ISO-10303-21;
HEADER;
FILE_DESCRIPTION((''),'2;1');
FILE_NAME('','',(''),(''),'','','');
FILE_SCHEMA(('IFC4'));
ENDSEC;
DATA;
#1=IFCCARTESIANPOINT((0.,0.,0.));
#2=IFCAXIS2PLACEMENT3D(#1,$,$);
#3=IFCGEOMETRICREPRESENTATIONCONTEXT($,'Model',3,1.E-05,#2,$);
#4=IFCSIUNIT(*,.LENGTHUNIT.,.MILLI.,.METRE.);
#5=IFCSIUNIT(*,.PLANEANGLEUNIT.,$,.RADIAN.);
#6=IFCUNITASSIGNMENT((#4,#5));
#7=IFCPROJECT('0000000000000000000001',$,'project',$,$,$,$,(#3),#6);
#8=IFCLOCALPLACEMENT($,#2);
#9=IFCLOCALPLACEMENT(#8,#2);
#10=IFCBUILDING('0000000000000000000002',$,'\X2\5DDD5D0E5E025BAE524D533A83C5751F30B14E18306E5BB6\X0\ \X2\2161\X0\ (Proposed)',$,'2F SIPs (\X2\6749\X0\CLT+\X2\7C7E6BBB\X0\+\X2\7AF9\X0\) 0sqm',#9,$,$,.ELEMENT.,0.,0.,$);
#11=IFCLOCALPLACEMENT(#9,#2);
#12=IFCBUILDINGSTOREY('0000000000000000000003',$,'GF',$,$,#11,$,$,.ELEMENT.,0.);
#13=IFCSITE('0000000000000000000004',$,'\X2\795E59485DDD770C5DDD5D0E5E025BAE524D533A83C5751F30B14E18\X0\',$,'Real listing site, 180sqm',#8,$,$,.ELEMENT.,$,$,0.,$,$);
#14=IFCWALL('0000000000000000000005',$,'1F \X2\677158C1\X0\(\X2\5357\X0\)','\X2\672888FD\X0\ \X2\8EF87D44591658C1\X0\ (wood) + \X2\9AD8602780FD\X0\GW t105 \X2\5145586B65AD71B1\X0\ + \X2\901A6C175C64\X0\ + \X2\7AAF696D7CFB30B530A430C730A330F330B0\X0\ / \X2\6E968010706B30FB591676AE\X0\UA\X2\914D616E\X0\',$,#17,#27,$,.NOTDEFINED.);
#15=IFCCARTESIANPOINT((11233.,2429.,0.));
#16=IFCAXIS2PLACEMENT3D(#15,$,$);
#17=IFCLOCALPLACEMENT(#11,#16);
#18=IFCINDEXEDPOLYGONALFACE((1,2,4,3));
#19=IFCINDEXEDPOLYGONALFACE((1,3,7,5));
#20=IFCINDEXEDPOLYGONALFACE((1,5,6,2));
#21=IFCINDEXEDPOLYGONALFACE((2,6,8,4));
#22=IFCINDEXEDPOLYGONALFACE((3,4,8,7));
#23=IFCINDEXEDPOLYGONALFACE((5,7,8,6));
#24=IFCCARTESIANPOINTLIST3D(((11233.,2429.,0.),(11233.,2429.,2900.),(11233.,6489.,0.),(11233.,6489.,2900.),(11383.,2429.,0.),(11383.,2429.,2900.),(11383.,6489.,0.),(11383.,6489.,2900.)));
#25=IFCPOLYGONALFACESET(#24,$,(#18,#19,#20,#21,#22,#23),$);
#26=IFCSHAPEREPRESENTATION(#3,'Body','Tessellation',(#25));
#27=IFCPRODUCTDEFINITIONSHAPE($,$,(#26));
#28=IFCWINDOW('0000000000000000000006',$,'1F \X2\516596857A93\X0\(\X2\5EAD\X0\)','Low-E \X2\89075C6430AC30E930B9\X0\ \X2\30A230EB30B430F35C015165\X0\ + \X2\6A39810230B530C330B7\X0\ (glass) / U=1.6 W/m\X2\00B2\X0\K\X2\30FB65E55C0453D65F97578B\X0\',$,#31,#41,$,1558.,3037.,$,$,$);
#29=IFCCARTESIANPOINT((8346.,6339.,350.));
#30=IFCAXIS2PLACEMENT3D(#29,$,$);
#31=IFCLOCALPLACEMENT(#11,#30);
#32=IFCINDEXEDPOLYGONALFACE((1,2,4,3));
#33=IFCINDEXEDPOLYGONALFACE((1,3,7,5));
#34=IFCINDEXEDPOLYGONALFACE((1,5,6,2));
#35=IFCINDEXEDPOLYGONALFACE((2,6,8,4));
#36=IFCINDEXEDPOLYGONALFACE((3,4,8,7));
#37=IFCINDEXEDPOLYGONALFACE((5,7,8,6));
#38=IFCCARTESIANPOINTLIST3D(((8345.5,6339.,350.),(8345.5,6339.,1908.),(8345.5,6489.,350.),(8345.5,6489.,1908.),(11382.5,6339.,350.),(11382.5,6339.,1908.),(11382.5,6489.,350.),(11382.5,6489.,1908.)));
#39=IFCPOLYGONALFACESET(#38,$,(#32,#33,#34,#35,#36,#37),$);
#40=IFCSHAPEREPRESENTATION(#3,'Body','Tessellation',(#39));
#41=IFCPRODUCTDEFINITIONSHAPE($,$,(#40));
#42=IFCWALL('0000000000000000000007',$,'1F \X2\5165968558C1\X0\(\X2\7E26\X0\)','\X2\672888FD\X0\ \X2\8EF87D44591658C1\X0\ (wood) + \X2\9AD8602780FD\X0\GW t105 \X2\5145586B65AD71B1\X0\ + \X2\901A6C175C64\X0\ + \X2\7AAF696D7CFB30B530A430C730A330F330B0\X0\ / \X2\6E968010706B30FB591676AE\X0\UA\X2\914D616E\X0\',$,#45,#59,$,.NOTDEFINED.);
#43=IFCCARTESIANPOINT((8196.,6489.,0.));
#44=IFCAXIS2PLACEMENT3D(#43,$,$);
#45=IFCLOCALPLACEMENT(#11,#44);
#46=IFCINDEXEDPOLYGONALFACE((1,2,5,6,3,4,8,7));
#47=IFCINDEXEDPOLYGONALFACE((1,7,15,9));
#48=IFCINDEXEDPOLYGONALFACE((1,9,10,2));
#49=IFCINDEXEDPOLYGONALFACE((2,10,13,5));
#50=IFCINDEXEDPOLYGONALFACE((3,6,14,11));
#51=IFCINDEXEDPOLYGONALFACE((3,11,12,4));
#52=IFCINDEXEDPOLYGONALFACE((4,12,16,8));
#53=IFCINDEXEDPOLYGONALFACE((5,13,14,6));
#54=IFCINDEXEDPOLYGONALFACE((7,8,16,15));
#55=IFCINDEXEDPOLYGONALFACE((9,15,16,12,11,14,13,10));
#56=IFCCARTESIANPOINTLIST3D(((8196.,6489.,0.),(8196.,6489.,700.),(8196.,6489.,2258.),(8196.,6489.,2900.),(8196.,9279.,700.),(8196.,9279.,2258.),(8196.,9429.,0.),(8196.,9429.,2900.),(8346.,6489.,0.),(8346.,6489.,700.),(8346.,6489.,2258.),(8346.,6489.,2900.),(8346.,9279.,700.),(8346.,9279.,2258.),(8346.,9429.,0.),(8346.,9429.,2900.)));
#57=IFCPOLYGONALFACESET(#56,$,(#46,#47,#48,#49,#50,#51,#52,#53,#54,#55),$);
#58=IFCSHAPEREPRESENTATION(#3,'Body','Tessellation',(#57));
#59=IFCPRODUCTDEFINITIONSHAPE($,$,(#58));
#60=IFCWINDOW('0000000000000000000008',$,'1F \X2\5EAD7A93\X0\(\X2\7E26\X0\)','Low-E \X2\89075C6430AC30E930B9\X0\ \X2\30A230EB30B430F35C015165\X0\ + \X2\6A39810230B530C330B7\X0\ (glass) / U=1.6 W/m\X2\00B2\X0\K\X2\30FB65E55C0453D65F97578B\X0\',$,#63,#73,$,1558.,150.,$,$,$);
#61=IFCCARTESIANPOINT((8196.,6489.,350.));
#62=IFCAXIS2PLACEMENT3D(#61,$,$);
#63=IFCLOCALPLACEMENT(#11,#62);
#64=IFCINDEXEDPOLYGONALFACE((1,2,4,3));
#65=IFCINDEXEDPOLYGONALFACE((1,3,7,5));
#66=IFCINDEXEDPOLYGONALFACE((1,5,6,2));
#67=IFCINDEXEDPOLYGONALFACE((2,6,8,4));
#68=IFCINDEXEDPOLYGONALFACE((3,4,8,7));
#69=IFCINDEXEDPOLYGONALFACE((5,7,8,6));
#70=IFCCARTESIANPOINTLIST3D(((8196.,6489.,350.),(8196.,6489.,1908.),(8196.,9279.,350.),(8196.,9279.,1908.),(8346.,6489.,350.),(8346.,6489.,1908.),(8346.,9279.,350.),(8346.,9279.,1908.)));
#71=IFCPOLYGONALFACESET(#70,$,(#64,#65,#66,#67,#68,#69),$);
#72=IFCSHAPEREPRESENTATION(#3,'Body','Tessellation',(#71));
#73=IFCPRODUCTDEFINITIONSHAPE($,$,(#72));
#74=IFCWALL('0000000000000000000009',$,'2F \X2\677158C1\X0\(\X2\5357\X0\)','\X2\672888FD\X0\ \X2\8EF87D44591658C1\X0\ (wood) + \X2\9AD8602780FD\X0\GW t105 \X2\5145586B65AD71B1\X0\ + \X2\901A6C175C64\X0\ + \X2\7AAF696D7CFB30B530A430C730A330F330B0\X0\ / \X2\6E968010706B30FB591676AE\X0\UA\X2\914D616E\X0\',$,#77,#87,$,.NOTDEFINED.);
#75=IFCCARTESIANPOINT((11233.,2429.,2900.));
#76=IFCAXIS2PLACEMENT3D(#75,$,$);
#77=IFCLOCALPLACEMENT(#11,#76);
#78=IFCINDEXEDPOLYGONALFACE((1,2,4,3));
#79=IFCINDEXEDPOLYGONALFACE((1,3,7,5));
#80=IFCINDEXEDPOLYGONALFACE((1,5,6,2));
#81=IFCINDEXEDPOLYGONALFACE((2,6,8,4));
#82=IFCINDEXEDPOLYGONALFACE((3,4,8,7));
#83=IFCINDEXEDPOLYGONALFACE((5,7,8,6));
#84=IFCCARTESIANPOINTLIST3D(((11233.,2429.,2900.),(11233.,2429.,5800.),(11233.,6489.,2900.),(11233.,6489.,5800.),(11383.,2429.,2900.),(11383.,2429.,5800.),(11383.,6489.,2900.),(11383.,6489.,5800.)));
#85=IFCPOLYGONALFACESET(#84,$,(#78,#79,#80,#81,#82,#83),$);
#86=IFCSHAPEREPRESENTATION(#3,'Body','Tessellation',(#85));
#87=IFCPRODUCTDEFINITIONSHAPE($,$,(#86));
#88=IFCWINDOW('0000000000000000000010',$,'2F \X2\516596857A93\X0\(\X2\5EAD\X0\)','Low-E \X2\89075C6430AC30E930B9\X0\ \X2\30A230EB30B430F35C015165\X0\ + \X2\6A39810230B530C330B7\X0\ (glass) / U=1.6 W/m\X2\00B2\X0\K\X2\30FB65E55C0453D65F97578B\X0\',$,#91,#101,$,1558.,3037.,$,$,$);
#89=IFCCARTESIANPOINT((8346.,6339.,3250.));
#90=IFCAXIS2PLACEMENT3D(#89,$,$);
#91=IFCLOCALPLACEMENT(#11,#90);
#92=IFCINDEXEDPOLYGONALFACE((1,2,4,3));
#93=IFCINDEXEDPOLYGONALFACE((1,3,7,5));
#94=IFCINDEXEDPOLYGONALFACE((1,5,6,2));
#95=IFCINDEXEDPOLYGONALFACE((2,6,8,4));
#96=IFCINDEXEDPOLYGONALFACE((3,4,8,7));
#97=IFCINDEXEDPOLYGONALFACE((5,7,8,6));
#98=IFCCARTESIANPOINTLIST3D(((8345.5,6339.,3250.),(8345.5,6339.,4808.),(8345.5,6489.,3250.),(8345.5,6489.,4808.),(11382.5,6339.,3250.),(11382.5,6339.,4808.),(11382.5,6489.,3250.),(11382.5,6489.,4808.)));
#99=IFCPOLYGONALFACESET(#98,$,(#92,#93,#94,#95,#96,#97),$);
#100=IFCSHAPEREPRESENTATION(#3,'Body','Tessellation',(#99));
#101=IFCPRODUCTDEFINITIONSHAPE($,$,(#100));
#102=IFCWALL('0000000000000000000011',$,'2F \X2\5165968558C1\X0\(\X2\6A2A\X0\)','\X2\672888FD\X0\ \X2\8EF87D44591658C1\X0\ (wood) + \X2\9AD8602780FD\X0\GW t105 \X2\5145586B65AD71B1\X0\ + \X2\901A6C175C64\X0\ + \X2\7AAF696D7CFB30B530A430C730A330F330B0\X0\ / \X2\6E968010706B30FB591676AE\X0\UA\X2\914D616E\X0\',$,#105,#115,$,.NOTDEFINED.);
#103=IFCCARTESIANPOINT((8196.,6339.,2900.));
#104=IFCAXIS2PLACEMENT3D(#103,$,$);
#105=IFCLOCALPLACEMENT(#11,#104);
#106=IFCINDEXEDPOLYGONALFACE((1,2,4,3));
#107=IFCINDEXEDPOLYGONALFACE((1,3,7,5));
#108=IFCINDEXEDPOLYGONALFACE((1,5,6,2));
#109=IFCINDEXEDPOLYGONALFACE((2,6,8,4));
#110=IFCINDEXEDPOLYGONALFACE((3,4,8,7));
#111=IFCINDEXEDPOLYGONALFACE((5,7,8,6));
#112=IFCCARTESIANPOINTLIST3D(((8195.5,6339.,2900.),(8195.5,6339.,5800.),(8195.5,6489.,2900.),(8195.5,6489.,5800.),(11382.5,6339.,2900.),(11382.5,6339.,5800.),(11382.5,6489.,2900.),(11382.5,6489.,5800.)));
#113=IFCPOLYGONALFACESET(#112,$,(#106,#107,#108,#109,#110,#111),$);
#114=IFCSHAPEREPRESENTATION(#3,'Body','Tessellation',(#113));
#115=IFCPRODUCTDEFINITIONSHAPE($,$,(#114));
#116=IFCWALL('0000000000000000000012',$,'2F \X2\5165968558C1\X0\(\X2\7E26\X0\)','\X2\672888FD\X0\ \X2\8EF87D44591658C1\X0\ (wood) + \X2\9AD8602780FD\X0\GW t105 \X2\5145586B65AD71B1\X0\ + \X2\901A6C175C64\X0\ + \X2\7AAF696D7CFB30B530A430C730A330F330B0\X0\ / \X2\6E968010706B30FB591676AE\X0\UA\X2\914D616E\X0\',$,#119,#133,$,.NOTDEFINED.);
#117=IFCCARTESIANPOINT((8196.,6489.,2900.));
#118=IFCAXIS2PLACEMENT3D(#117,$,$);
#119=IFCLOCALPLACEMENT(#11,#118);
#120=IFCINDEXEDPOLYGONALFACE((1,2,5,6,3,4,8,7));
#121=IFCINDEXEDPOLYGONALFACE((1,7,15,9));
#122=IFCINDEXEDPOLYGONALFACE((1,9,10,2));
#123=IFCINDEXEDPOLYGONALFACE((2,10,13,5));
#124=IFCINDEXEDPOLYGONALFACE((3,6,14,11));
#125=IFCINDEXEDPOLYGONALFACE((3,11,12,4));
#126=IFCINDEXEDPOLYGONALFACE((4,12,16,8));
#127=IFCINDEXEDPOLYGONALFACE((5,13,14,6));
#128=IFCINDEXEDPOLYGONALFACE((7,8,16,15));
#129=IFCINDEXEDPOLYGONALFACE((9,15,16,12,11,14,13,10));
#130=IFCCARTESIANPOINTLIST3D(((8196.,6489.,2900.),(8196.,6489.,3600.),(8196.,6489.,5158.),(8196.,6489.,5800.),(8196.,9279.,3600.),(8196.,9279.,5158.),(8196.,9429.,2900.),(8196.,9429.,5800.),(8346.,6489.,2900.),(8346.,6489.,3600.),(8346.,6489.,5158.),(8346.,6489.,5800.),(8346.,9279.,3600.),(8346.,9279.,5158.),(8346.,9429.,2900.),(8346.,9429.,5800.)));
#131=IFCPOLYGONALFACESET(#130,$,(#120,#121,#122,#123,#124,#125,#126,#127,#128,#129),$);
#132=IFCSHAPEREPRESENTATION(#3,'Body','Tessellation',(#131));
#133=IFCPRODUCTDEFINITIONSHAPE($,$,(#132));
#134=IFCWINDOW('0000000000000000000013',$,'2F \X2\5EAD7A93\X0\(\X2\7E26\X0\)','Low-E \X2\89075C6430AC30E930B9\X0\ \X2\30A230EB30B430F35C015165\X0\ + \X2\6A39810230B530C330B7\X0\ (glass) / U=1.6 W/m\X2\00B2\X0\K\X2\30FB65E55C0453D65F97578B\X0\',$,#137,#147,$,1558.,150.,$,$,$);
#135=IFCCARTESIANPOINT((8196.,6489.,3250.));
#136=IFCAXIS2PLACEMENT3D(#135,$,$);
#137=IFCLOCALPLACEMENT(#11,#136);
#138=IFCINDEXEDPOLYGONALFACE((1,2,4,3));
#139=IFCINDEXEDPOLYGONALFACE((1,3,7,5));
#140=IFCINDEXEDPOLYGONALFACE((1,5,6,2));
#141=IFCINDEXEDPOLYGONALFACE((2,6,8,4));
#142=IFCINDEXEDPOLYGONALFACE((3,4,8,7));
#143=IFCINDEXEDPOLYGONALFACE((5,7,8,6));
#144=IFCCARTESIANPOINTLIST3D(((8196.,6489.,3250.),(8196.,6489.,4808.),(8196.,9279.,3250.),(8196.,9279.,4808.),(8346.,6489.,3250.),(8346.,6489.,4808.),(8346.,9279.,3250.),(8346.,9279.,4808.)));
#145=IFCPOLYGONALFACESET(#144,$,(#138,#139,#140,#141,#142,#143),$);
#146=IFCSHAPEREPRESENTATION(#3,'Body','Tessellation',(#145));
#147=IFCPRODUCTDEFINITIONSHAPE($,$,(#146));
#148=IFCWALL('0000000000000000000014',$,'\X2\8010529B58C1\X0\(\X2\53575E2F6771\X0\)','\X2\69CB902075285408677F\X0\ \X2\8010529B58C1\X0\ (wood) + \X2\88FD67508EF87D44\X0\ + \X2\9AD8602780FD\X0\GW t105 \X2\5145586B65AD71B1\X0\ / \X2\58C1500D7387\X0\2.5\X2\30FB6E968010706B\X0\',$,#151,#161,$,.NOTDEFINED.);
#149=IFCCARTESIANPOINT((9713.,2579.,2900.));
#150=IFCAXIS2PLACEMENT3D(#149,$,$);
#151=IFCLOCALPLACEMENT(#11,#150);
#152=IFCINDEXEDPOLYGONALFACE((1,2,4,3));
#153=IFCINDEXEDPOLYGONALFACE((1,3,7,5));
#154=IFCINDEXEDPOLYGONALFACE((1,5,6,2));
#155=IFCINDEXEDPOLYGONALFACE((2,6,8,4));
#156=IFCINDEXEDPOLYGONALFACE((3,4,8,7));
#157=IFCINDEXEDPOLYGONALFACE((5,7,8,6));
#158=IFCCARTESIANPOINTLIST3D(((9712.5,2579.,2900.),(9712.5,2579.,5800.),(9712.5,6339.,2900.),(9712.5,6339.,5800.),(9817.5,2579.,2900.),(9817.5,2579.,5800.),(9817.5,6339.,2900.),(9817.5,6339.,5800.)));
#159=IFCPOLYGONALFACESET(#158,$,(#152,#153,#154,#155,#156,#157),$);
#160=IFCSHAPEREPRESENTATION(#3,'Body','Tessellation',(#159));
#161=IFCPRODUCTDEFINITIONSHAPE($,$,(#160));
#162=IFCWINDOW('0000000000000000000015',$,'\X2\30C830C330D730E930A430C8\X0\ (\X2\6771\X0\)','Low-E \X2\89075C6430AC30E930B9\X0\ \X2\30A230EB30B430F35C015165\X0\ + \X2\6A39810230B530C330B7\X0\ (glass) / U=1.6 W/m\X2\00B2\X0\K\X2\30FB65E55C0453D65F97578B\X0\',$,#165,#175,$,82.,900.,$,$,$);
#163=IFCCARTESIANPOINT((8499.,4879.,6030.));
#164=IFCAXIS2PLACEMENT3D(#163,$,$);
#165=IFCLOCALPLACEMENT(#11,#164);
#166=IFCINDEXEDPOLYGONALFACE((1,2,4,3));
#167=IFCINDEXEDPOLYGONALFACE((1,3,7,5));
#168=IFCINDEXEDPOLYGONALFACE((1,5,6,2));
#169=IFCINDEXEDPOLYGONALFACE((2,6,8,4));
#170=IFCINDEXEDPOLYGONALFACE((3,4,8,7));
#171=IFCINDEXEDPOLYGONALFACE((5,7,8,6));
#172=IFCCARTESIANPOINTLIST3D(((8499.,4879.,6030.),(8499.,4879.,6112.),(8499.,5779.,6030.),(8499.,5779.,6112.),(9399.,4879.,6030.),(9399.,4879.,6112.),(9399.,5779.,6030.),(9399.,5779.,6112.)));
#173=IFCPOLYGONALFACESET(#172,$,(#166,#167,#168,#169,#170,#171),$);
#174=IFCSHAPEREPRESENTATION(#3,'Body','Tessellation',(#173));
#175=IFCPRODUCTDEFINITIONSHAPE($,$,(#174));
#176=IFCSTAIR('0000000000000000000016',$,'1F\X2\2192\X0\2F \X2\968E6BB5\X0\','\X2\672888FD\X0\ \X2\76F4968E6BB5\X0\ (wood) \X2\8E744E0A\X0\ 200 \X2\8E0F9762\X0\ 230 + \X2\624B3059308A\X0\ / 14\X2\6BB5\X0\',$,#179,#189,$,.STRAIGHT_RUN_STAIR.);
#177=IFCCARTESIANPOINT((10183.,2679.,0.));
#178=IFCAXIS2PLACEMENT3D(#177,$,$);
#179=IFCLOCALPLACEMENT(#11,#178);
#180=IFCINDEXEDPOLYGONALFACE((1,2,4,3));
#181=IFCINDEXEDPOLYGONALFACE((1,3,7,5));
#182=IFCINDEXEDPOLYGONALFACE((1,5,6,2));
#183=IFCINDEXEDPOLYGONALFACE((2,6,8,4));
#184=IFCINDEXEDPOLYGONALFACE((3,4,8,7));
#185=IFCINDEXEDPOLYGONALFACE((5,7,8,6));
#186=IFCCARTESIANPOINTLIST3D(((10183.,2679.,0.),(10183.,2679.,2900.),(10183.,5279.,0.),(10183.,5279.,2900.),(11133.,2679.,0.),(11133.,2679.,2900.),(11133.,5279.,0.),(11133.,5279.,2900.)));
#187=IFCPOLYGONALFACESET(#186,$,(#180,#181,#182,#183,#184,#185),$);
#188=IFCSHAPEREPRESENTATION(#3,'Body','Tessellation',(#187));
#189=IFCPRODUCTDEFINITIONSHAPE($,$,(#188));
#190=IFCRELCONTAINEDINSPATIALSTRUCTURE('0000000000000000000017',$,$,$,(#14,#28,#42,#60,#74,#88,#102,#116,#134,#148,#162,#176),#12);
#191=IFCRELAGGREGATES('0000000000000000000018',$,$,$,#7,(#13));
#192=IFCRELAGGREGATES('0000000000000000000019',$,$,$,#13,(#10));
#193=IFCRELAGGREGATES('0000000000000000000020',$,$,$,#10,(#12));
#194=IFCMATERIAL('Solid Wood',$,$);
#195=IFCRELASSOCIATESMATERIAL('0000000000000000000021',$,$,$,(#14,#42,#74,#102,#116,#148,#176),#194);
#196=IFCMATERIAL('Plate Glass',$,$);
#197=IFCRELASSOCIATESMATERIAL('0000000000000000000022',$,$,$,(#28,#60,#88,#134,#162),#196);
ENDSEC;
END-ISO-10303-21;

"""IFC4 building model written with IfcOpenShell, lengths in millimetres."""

from ifc_helpers import new_model, si_unit, frame, frame_2d, origin, place, context, project, spatial, rectangle, extrude, material, element, fill, save


model = new_model("IFC4")

# Units and contexts
model_context = context("Model", 3, precision=1e-05, world=origin())
ifc_project = project(units=[si_unit("LENGTHUNIT", "METRE", prefix="MILLI"), si_unit("PLANEANGLEUNIT", "RADIAN")], contexts=[model_context])

# Site, building, storey
site_placement = place(None, origin())
site = spatial("IfcSite", under=ifc_project, at=site_placement, Name="神奈川県川崎市宮前区菅生ケ丘", ObjectType="Real listing site, 180sqm", CompositionType="ELEMENT", RefElevation=0.0)
building_placement = place(site_placement, origin())
building = spatial("IfcBuilding", under=site, at=building_placement, Name="川崎市宮前区菅生ケ丘の家 Ⅱ (Proposed)", ObjectType="2F SIPs (杉CLT+籾殻+竹) 0sqm", CompositionType="ELEMENT", ElevationOfRefHeight=0.0, ElevationOfTerrain=0.0)
storey_placement = place(building_placement, origin())
storey = spatial("IfcBuildingStorey", under=building, at=storey_placement, Name="GF", CompositionType="ELEMENT", Elevation=0.0)

# Shared definitions
ifc_material_1 = material(Name="Solid Wood")

# Wall, opening, window
wall_1_placement = place(storey_placement, frame((11233.0, 2429.0, 0.0)))
wall_1 = element("IfcWall", 1, at=wall_1_placement, inside=storey, material=ifc_material_1, Name="1F 東壁(南)", Description="木製 軸組外壁 (wood) + 高性能GW t105 充填断熱 + 通気層 + 窯業系サイディング / 準耐火・外皮UA配慮", PredefinedType="NOTDEFINED", context=model_context, shape_type="SweptSolid", body=[
    extrude(rectangle(XDim=150.0, YDim=4060.0, at=frame_2d((75.0, 2030.0))), frame((11233.0, 2429.0, 0.0)), (0.0, 0.0, 1.0), 2900.0),
])
opening_1_placement = place(storey_placement, frame((8346.0, 6339.0, 350.0)))
opening_1 = element("IfcOpeningElement", 2, at=opening_1_placement, cuts=wall_1, PredefinedType="NOTDEFINED", context=model_context, shape_type="SweptSolid", body=[
    extrude(rectangle(XDim=3037.0, YDim=150.0, at=frame_2d((1518.0, 75.0))), frame((8346.0, 6339.0, 350.0)), (0.0, 0.0, 1.0), 1558.0),
])
ifc_material_2 = material(Name="Plate Glass")
window_1_placement = place(storey_placement, frame((8346.0, 6339.0, 350.0)))
window_1 = element("IfcWindow", 3, at=window_1_placement, inside=storey, material=ifc_material_2, Name="1F 入隅窓(庭)", Description="Low-E 複層ガラス アルゴン封入 + 樹脂サッシ (glass) / U=1.6 W/m²K・日射取得型", OverallHeight=1558.0, OverallWidth=3037.0, context=model_context, shape_type="SweptSolid", body=[
    extrude(rectangle(XDim=3037.0, YDim=150.0, at=frame_2d((1518.0, 75.0))), frame((8346.0, 6339.0, 350.0)), (0.0, 0.0, 1.0), 1558.0),
])
fill(opening_1, window_1)

# Wall, opening, window
wall_2_placement = place(storey_placement, frame((8196.0, 6489.0, 0.0)))
wall_2 = element("IfcWall", 4, at=wall_2_placement, inside=storey, material=ifc_material_1, Name="1F 入隅壁(縦)", Description="木製 軸組外壁 (wood) + 高性能GW t105 充填断熱 + 通気層 + 窯業系サイディング / 準耐火・外皮UA配慮", PredefinedType="NOTDEFINED", context=model_context, shape_type="SweptSolid", body=[
    extrude(rectangle(XDim=150.0, YDim=2940.0, at=frame_2d((75.0, 1470.0))), frame((8196.0, 6489.0, 0.0)), (0.0, 0.0, 1.0), 2900.0),
])
opening_2_placement = place(storey_placement, frame((8196.0, 6489.0, 350.0)))
opening_2 = element("IfcOpeningElement", 5, at=opening_2_placement, cuts=wall_2, PredefinedType="NOTDEFINED", context=model_context, shape_type="SweptSolid", body=[
    extrude(rectangle(XDim=150.0, YDim=2790.0, at=frame_2d((75.0, 1395.0))), frame((8196.0, 6489.0, 350.0)), (0.0, 0.0, 1.0), 1558.0),
])
window_2_placement = place(storey_placement, frame((8196.0, 6489.0, 350.0)))
window_2 = element("IfcWindow", 6, at=window_2_placement, inside=storey, material=ifc_material_2, Name="1F 庭窓(縦)", Description="Low-E 複層ガラス アルゴン封入 + 樹脂サッシ (glass) / U=1.6 W/m²K・日射取得型", OverallHeight=1558.0, OverallWidth=150.0, context=model_context, shape_type="SweptSolid", body=[
    extrude(rectangle(XDim=150.0, YDim=2790.0, at=frame_2d((75.0, 1395.0))), frame((8196.0, 6489.0, 350.0)), (0.0, 0.0, 1.0), 1558.0),
])
fill(opening_2, window_2)

# Wall, opening, window
wall_3_placement = place(storey_placement, frame((11233.0, 2429.0, 2900.0)))
wall_3 = element("IfcWall", 7, at=wall_3_placement, inside=storey, material=ifc_material_1, Name="2F 東壁(南)", Description="木製 軸組外壁 (wood) + 高性能GW t105 充填断熱 + 通気層 + 窯業系サイディング / 準耐火・外皮UA配慮", PredefinedType="NOTDEFINED", context=model_context, shape_type="SweptSolid", body=[
    extrude(rectangle(XDim=150.0, YDim=4060.0, at=frame_2d((75.0, 2030.0))), frame((11233.0, 2429.0, 2900.0)), (0.0, 0.0, 1.0), 2900.0),
])
opening_3_placement = place(storey_placement, frame((8346.0, 6339.0, 3250.0)))
opening_3 = element("IfcOpeningElement", 8, at=opening_3_placement, cuts=wall_3, PredefinedType="NOTDEFINED", context=model_context, shape_type="SweptSolid", body=[
    extrude(rectangle(XDim=3037.0, YDim=150.0, at=frame_2d((1518.0, 75.0))), frame((8346.0, 6339.0, 3250.0)), (0.0, 0.0, 1.0), 1558.0),
])
window_3_placement = place(storey_placement, frame((8346.0, 6339.0, 3250.0)))
window_3 = element("IfcWindow", 9, at=window_3_placement, inside=storey, material=ifc_material_2, Name="2F 入隅窓(庭)", Description="Low-E 複層ガラス アルゴン封入 + 樹脂サッシ (glass) / U=1.6 W/m²K・日射取得型", OverallHeight=1558.0, OverallWidth=3037.0, context=model_context, shape_type="SweptSolid", body=[
    extrude(rectangle(XDim=3037.0, YDim=150.0, at=frame_2d((1518.0, 75.0))), frame((8346.0, 6339.0, 3250.0)), (0.0, 0.0, 1.0), 1558.0),
])
fill(opening_3, window_3)

# Wall
wall_4_placement = place(storey_placement, frame((8196.0, 6339.0, 2900.0)))
element("IfcWall", 10, at=wall_4_placement, inside=storey, material=ifc_material_1, Name="2F 入隅壁(横)", Description="木製 軸組外壁 (wood) + 高性能GW t105 充填断熱 + 通気層 + 窯業系サイディング / 準耐火・外皮UA配慮", PredefinedType="NOTDEFINED", context=model_context, shape_type="SweptSolid", body=[
    extrude(rectangle(XDim=3187.0, YDim=150.0, at=frame_2d((1593.0, 75.0))), frame((8196.0, 6339.0, 2900.0)), (0.0, 0.0, 1.0), 2900.0),
])

# Wall, opening, window
wall_5_placement = place(storey_placement, frame((8196.0, 6489.0, 2900.0)))
wall_5 = element("IfcWall", 11, at=wall_5_placement, inside=storey, material=ifc_material_1, Name="2F 入隅壁(縦)", Description="木製 軸組外壁 (wood) + 高性能GW t105 充填断熱 + 通気層 + 窯業系サイディング / 準耐火・外皮UA配慮", PredefinedType="NOTDEFINED", context=model_context, shape_type="SweptSolid", body=[
    extrude(rectangle(XDim=150.0, YDim=2940.0, at=frame_2d((75.0, 1470.0))), frame((8196.0, 6489.0, 2900.0)), (0.0, 0.0, 1.0), 2900.0),
])
opening_4_placement = place(storey_placement, frame((8196.0, 6489.0, 3250.0)))
opening_4 = element("IfcOpeningElement", 12, at=opening_4_placement, cuts=wall_5, PredefinedType="NOTDEFINED", context=model_context, shape_type="SweptSolid", body=[
    extrude(rectangle(XDim=150.0, YDim=2790.0, at=frame_2d((75.0, 1395.0))), frame((8196.0, 6489.0, 3250.0)), (0.0, 0.0, 1.0), 1558.0),
])
window_4_placement = place(storey_placement, frame((8196.0, 6489.0, 3250.0)))
window_4 = element("IfcWindow", 13, at=window_4_placement, inside=storey, material=ifc_material_2, Name="2F 庭窓(縦)", Description="Low-E 複層ガラス アルゴン封入 + 樹脂サッシ (glass) / U=1.6 W/m²K・日射取得型", OverallHeight=1558.0, OverallWidth=150.0, context=model_context, shape_type="SweptSolid", body=[
    extrude(rectangle(XDim=150.0, YDim=2790.0, at=frame_2d((75.0, 1395.0))), frame((8196.0, 6489.0, 3250.0)), (0.0, 0.0, 1.0), 1558.0),
])
fill(opening_4, window_4)

# Wall
wall_6_placement = place(storey_placement, frame((9713.0, 2579.0, 2900.0)))
element("IfcWall", 14, at=wall_6_placement, inside=storey, material=ifc_material_1, Name="耐力壁(南帯東)", Description="構造用合板 耐力壁 (wood) + 製材軸組 + 高性能GW t105 充填断熱 / 壁倍率2.5・準耐火", PredefinedType="NOTDEFINED", context=model_context, shape_type="SweptSolid", body=[
    extrude(rectangle(XDim=105.0, YDim=3760.0, at=frame_2d((52.0, 1880.0))), frame((9713.0, 2579.0, 2900.0)), (0.0, 0.0, 1.0), 2900.0),
])

# Window
window_5_placement = place(storey_placement, frame((8499.0, 4879.0, 6030.0)))
element("IfcWindow", 15, at=window_5_placement, inside=storey, material=ifc_material_2, Name="トップライト (東)", Description="Low-E 複層ガラス アルゴン封入 + 樹脂サッシ (glass) / U=1.6 W/m²K・日射取得型", OverallHeight=82.0, OverallWidth=900.0, context=model_context, shape_type="SweptSolid", body=[
    extrude(rectangle(XDim=900.0, YDim=900.0, at=frame_2d((450.0, 450.0))), frame((8499.0, 4879.0, 6030.0)), (0.0, 0.0, 1.0), 82.0),
])

# Stair
stair_placement = place(storey_placement, frame((10183.0, 2679.0, 0.0)))
element("IfcStair", 16, at=stair_placement, inside=storey, material=ifc_material_1, Name="1F→2F 階段", Description="木製 直階段 (wood) 蹴上 200 踏面 230 + 手すり / 14段", PredefinedType="STRAIGHT_RUN_STAIR", context=model_context, shape_type="SweptSolid", body=[
    extrude(rectangle(XDim=950.0, YDim=2600.0, at=frame_2d((475.0, 1300.0))), frame((10183.0, 2679.0, 0.0)), (0.0, 0.0, 1.0), 2900.0),
])

save(model, "model.ifc")
